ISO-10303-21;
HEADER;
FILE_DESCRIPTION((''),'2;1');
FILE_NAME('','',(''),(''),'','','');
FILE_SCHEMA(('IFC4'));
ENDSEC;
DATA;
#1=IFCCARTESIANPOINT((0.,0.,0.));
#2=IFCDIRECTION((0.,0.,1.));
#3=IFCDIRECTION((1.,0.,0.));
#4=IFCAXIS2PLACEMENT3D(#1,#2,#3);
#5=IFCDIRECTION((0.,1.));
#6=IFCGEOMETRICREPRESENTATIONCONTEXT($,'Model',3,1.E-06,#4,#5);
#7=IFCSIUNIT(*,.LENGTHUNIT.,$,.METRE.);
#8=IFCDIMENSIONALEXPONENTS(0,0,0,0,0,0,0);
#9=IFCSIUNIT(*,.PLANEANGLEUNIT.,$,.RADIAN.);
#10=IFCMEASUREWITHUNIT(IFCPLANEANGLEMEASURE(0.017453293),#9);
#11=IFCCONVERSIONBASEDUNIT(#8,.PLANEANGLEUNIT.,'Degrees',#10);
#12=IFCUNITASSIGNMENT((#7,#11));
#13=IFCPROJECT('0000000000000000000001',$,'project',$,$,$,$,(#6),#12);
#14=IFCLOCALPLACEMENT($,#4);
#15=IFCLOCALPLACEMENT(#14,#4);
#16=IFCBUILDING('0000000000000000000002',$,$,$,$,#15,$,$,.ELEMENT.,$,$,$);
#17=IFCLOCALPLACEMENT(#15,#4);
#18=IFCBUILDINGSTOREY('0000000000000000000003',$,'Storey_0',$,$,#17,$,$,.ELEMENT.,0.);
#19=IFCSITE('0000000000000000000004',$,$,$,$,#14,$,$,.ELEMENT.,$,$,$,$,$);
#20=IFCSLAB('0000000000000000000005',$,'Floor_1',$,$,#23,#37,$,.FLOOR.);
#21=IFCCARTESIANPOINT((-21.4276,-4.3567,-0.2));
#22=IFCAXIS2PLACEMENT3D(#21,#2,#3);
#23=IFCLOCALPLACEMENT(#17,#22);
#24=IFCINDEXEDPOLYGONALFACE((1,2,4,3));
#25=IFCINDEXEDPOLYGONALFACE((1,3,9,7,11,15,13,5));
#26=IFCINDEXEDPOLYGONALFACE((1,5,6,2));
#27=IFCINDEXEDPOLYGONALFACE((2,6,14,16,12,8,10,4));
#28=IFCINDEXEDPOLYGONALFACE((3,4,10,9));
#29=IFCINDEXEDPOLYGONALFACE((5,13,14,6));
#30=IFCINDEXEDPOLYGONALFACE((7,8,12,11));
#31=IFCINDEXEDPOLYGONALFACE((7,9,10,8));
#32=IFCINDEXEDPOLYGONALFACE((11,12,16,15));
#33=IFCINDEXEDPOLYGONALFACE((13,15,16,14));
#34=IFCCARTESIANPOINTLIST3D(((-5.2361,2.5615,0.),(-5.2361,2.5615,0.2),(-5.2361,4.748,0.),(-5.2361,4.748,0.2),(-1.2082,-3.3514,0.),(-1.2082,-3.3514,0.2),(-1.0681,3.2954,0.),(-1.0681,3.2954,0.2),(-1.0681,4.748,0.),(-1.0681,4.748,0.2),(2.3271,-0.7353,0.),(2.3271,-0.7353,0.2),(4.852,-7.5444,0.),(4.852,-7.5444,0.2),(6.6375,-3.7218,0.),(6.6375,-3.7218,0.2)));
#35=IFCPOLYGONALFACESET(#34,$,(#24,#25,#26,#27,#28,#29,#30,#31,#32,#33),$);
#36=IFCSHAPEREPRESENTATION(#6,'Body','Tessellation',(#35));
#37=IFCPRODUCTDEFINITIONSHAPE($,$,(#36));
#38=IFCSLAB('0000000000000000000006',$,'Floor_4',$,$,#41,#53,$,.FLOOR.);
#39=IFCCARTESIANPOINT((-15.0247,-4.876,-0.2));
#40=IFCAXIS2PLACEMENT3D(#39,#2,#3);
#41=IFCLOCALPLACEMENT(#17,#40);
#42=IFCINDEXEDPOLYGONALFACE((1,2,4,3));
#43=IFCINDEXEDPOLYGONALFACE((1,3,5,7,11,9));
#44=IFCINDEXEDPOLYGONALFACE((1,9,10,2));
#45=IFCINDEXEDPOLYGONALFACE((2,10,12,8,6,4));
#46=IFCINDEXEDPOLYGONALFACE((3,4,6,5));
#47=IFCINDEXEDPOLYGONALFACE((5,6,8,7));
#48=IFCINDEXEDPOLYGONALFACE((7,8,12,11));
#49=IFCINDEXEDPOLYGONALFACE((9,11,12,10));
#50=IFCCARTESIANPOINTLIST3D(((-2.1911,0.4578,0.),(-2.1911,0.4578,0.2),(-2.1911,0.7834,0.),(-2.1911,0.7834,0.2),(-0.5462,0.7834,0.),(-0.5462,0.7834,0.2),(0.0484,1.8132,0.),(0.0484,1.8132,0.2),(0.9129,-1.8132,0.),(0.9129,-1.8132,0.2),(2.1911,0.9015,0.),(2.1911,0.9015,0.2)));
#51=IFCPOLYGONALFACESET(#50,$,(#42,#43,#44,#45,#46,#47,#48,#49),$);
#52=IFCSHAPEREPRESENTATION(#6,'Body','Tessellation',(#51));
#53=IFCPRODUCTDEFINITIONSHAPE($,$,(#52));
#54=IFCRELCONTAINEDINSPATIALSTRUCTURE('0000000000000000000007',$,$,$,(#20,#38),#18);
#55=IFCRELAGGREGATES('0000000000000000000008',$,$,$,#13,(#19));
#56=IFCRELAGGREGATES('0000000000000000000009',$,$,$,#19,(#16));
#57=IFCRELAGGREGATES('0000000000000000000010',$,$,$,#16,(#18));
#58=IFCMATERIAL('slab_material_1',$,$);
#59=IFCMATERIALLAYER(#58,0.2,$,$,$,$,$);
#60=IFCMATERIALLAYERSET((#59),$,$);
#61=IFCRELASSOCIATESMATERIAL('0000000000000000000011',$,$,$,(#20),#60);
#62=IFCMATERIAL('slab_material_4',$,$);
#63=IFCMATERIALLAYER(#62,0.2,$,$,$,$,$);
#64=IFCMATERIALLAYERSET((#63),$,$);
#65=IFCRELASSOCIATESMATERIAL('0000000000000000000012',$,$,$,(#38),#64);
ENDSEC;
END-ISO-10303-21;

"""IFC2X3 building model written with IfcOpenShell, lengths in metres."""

from ifc_helpers import new_model, entity, si_unit, converted_unit, direction, frame, origin_with_axes, place, context, project, spatial, polyline, outline, extrude, material, layer, layer_set, layer_usage, element, save


model = new_model("IFC2X3")

# Units and contexts
model_context = context("Model", 3, precision=1e-06, world=origin_with_axes(), true_north=direction((0.0, 1.0)))
ifc_project = project(units=[si_unit("LENGTHUNIT", "METRE"), converted_unit("PLANEANGLEUNIT", "Degrees", entity("IfcPlaneAngleMeasure", 0.017453293), si_unit("PLANEANGLEUNIT", "RADIAN"), dimensions=[0, 0, 0, 0, 0, 0, 0])], contexts=[model_context])

# Site, building, storey
site_placement = place(None, origin_with_axes())
site = spatial("IfcSite", under=ifc_project, at=site_placement, CompositionType="ELEMENT")
building_placement = place(site_placement, origin_with_axes())
building = spatial("IfcBuilding", under=site, at=building_placement, CompositionType="ELEMENT")
storey_placement = place(building_placement, origin_with_axes())
storey = spatial("IfcBuildingStorey", under=building, at=storey_placement, Name="Storey_0", CompositionType="ELEMENT", Elevation=0.0)

# Slabs
ifc_material_1 = material(Name="slab_material_1")
ifc_layer_1 = layer(ifc_material_1, 0.2)
ifc_layer_set_1 = layer_set([ifc_layer_1])
ifc_layer_usage_1 = layer_usage(ifc_layer_set_1, "AXIS3", "POSITIVE", 0.0)
slab_1_placement = place(storey_placement, frame((-21.4276, -4.3567, -0.2), z_axis=(0.0, 0.0, 1.0), x_axis=(1.0, 0.0, 0.0)))
element("IfcSlab", 1, at=slab_1_placement, inside=storey, material=ifc_layer_usage_1, Name="Floor_1", PredefinedType="FLOOR", context=model_context, shape_type="SweptSolid", body=[
    extrude(outline(polyline([(-5.2361, 4.748), (-5.2361, 2.5615), (-1.2082, -3.3514), (4.852, -7.5444), (6.6375, -3.7218), (2.3271, -0.7353), (-1.0681, 3.2954), (-1.0681, 4.748), (-5.2361, 4.748)])), origin_with_axes(), (0.0, 0.0, 1.0), 0.2),
])
ifc_material_2 = material(Name="slab_material_4")
ifc_layer_2 = layer(ifc_material_2, 0.2)
ifc_layer_set_2 = layer_set([ifc_layer_2])
ifc_layer_usage_2 = layer_usage(ifc_layer_set_2, "AXIS3", "POSITIVE", 0.0)
slab_2_placement = place(storey_placement, frame((-15.0247, -4.876, -0.2), z_axis=(0.0, 0.0, 1.0), x_axis=(1.0, 0.0, 0.0)))
element("IfcSlab", 2, at=slab_2_placement, inside=storey, material=ifc_layer_usage_2, Name="Floor_4", PredefinedType="FLOOR", context=model_context, shape_type="SweptSolid", body=[
    extrude(outline(polyline([(2.1911, 0.9015), (0.9129, -1.8132), (-2.1911, 0.4578), (-2.1911, 0.7834), (-0.5462, 0.7834), (0.0484, 1.8132), (2.1911, 0.9015)])), origin_with_axes(), (0.0, 0.0, 1.0), 0.2),
])

save(model, "model.ifc")
